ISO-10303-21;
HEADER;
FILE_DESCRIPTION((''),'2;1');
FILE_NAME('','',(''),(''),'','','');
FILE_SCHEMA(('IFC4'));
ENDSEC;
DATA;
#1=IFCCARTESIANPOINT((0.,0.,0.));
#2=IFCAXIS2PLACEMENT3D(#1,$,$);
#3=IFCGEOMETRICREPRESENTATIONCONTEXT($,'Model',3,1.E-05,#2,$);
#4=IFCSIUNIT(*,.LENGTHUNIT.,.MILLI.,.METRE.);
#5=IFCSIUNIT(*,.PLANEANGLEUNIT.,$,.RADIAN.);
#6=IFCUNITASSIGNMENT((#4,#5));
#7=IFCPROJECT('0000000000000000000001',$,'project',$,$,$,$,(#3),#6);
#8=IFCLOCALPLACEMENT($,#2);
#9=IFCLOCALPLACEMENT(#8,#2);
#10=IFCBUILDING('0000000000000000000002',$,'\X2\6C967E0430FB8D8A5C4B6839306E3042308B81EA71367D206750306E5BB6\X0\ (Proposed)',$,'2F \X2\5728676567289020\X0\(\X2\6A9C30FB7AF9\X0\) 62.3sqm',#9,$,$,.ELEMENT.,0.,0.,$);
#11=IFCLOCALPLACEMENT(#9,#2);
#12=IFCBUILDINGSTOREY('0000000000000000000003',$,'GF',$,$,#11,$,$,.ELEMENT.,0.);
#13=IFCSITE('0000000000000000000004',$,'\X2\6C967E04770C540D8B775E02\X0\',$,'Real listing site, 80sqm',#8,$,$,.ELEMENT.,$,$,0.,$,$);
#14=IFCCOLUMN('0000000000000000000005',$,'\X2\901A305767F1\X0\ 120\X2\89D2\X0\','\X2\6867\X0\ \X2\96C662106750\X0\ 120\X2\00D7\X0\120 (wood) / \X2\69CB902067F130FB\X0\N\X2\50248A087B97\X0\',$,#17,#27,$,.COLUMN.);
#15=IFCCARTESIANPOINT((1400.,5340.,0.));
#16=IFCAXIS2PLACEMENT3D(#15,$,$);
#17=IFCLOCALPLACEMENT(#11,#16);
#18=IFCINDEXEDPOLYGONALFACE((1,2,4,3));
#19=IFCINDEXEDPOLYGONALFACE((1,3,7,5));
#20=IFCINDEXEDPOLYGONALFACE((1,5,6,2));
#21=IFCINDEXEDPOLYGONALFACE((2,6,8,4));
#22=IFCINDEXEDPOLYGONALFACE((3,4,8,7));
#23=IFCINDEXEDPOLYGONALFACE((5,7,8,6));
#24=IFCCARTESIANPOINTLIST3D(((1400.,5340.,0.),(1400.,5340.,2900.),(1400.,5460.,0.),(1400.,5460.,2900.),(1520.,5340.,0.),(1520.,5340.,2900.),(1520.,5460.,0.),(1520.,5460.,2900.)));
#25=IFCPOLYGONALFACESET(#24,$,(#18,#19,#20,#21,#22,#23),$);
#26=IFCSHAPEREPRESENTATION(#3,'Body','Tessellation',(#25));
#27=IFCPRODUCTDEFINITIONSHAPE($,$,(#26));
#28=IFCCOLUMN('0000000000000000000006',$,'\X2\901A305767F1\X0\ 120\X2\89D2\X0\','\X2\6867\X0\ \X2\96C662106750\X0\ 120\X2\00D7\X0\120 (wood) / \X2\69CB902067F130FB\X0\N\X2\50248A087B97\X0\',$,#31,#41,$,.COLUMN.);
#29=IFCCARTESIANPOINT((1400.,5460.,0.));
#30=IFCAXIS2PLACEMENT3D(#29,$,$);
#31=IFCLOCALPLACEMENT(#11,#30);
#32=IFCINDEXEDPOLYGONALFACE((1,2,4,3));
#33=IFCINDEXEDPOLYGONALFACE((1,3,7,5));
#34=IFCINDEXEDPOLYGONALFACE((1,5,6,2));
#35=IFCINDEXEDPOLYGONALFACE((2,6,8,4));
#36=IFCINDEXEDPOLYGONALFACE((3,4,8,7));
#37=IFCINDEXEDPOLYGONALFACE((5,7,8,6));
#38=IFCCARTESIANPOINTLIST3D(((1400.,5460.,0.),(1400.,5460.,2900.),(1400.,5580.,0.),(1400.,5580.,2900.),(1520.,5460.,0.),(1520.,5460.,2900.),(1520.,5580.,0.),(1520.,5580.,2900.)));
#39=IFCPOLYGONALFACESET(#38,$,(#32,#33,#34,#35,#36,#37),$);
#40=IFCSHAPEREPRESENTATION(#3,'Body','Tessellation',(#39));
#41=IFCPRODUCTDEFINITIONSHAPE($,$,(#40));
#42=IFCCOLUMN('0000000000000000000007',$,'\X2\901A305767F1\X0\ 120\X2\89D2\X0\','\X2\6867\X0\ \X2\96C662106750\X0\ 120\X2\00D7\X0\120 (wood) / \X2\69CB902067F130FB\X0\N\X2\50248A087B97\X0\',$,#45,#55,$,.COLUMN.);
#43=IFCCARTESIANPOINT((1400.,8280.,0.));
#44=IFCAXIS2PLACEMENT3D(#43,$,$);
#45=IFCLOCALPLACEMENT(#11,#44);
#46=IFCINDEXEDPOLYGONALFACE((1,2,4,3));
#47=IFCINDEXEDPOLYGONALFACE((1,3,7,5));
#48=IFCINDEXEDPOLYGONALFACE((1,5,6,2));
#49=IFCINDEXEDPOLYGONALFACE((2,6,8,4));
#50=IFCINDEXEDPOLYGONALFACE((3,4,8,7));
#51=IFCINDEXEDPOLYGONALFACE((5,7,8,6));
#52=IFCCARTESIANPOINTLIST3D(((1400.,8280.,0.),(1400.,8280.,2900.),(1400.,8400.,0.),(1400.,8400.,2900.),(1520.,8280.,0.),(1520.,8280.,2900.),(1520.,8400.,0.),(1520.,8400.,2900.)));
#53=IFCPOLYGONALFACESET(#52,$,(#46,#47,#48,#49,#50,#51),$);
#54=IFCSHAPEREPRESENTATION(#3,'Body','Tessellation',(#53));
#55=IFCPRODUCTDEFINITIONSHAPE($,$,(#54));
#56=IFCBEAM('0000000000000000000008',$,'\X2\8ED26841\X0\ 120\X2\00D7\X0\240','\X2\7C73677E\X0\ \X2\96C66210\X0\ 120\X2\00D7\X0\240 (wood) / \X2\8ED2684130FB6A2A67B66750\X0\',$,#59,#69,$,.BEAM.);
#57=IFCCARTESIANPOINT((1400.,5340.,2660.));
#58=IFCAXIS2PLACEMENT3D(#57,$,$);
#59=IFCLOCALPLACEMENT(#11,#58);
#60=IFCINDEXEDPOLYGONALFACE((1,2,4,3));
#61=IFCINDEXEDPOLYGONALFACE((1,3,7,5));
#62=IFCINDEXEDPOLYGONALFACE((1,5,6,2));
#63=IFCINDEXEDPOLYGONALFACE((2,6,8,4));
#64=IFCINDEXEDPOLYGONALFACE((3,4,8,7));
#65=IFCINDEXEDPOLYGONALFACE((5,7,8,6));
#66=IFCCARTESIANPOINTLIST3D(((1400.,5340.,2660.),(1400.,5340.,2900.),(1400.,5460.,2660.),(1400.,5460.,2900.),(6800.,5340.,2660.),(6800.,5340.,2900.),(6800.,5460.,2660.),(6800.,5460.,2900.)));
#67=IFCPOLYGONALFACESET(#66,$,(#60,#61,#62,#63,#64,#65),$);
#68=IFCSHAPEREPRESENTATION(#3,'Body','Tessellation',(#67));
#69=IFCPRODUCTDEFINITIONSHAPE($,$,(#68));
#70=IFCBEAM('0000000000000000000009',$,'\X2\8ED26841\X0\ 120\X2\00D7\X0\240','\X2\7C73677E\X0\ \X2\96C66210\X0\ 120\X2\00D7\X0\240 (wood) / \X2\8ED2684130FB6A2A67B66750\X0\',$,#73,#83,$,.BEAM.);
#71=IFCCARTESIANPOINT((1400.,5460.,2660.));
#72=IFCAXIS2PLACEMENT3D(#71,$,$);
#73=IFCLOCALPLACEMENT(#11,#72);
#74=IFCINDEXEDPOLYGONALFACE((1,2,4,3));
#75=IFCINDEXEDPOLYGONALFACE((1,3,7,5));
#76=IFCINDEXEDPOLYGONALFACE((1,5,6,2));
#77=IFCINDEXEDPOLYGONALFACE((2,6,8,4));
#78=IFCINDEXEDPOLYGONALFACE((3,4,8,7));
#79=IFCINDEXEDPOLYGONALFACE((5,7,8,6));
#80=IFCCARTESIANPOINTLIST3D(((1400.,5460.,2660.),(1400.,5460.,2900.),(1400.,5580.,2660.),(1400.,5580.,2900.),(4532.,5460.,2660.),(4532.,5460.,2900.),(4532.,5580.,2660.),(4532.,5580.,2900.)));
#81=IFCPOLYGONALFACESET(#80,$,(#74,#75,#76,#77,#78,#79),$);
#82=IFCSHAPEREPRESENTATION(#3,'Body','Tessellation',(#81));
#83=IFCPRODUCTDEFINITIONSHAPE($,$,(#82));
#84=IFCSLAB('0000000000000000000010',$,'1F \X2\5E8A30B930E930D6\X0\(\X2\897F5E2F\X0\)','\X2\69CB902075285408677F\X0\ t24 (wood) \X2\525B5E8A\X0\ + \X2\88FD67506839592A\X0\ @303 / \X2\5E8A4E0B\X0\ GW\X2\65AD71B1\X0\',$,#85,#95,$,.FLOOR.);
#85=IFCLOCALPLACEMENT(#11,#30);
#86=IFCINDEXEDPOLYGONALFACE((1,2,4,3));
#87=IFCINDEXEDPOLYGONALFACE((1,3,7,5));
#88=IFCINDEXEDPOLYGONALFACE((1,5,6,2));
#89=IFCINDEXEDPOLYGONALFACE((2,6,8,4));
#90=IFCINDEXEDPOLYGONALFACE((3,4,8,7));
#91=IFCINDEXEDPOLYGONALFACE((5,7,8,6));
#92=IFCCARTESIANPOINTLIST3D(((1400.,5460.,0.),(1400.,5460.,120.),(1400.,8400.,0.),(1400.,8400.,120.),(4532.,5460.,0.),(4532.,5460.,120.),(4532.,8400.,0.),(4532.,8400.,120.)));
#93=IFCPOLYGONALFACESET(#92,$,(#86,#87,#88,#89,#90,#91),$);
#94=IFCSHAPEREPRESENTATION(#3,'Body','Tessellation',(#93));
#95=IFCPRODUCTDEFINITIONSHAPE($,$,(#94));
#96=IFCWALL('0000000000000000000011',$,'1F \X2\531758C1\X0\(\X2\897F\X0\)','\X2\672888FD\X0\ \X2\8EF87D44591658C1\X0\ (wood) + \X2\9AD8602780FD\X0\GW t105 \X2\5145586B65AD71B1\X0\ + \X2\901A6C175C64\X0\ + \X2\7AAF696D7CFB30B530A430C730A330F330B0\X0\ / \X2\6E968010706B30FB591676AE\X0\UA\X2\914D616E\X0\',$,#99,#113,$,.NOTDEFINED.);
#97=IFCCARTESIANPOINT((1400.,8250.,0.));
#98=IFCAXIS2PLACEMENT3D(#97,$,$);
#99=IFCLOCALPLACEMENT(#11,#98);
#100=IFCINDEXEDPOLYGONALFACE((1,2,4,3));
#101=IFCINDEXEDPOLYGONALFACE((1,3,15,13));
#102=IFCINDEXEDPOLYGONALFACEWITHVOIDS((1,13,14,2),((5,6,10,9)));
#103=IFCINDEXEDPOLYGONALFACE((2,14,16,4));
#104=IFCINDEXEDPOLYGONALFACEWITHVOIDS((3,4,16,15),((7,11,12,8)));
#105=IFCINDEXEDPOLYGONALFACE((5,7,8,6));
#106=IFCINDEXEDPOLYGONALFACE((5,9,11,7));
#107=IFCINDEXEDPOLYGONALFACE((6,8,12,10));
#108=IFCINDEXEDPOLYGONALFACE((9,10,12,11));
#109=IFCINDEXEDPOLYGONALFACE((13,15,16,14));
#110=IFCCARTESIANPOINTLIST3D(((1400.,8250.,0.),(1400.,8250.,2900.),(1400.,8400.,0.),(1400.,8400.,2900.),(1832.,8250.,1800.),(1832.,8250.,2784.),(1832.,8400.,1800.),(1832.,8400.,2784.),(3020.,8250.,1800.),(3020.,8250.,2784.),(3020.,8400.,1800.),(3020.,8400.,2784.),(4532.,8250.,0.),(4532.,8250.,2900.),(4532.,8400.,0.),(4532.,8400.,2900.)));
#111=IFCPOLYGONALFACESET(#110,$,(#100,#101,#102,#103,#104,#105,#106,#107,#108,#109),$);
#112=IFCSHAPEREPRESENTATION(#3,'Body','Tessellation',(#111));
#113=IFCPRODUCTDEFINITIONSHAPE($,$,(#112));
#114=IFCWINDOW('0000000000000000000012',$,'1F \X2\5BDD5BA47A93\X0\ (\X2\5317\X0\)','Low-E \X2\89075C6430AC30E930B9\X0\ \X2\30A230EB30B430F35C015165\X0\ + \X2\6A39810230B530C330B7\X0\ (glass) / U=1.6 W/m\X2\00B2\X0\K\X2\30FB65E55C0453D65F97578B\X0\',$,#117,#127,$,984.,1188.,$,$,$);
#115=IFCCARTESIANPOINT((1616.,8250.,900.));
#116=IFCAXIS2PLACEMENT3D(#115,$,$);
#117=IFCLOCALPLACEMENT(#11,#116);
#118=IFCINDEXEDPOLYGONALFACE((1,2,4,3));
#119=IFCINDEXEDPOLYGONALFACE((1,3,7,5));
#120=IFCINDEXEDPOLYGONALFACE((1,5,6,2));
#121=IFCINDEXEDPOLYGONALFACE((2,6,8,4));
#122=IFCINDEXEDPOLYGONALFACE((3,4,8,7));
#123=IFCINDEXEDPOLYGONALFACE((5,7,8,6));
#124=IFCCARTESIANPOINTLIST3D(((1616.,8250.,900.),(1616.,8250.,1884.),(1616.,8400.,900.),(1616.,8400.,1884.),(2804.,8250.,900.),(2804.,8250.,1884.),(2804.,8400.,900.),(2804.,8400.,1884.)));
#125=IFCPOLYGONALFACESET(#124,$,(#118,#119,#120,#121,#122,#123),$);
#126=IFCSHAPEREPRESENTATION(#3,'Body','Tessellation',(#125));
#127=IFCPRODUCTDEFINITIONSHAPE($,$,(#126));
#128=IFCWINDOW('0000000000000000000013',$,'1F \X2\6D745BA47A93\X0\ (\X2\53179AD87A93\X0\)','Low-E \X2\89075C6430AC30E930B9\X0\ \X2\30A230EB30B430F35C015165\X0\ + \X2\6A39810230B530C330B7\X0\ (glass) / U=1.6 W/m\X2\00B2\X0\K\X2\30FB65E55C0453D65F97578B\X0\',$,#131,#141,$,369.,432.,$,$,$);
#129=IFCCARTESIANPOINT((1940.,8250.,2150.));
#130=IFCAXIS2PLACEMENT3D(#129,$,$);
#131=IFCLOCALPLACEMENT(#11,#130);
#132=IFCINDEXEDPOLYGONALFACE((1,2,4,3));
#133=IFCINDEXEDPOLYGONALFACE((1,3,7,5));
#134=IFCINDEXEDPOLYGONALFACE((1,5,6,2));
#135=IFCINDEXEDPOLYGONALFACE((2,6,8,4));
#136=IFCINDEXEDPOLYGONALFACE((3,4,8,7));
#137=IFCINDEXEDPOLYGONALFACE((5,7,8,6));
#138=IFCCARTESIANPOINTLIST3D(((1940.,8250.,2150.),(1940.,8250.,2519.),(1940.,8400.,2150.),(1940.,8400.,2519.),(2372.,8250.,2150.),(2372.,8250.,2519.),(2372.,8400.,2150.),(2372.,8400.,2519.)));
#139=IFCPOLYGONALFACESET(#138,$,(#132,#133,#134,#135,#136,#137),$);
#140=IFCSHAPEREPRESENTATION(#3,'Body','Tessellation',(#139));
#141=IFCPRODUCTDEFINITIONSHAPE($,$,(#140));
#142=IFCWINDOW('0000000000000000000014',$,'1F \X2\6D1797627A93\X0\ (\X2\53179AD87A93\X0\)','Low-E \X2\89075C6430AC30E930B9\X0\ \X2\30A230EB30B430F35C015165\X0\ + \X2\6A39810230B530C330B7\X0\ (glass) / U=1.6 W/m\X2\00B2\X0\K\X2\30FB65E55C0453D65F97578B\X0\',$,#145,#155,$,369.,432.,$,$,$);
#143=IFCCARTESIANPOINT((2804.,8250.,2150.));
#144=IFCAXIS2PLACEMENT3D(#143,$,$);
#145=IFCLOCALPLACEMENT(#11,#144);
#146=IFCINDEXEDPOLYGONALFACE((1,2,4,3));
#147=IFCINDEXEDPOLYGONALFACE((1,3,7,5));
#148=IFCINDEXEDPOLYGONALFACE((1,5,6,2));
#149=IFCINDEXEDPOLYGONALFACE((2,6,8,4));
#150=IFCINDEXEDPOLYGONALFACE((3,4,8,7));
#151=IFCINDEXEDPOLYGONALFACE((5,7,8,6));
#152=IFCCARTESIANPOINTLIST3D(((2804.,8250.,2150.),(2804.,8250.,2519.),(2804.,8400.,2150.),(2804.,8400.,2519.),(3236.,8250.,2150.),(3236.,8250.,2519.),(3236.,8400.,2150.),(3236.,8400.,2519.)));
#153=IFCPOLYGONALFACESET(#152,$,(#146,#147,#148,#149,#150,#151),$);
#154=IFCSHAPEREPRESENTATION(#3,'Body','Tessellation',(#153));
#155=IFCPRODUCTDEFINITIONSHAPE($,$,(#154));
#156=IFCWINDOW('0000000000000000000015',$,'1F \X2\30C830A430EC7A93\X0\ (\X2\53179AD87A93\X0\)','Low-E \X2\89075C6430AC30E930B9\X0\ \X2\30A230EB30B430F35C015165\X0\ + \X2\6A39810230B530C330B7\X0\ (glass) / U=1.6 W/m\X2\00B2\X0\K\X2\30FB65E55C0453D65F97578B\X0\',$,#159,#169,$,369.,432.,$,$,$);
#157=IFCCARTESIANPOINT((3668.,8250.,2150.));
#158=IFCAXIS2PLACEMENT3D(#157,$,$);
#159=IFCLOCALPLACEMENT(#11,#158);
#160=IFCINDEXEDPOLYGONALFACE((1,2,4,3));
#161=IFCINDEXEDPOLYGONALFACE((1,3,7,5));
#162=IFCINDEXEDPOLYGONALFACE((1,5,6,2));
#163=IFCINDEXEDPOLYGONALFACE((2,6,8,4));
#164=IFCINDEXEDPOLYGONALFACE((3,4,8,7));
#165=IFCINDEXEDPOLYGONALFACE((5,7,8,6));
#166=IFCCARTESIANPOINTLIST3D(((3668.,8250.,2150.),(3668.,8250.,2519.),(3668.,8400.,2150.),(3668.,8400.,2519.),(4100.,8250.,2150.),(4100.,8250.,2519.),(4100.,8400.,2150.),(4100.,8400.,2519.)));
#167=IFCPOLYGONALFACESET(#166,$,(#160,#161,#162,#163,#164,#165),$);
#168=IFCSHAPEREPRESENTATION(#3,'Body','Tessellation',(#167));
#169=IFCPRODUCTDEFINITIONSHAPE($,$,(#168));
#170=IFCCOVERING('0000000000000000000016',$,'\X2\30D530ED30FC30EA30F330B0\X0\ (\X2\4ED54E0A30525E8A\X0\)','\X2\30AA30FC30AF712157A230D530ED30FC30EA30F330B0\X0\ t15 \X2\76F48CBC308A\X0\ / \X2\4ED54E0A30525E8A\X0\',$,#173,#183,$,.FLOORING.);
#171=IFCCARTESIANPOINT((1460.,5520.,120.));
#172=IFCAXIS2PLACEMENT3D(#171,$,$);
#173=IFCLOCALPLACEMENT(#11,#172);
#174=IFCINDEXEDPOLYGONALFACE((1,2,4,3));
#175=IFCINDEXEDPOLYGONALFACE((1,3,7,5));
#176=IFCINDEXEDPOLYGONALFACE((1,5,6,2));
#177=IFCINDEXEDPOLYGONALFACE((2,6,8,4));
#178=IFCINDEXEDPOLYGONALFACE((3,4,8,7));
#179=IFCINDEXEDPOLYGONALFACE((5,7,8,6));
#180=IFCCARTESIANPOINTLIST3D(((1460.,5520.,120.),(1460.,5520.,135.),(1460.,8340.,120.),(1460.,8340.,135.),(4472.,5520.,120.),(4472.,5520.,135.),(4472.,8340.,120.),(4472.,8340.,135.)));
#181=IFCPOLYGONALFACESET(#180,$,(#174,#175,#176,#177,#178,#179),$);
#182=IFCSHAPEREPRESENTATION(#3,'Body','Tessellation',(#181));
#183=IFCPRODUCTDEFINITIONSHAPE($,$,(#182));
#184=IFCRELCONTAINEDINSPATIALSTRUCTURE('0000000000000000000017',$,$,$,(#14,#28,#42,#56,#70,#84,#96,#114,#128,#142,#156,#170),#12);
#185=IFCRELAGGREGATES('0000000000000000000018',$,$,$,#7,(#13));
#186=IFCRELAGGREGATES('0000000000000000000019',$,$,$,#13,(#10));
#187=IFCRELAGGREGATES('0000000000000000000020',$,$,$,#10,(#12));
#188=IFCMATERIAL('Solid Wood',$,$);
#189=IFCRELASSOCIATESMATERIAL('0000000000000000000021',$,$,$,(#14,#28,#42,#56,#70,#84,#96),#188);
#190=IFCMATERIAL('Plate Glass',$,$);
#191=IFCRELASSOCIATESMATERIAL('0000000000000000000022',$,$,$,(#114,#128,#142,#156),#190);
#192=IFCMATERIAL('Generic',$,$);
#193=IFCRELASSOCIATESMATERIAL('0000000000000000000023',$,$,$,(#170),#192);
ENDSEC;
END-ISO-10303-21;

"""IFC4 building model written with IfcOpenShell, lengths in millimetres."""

from ifc_helpers import new_model, si_unit, frame, frame_2d, origin, place, context, project, spatial, rectangle, extrude, material, element, fill, save


model = new_model("IFC4")

# Units and contexts
model_context = context("Model", 3, precision=1e-05, world=origin())
ifc_project = project(units=[si_unit("LENGTHUNIT", "METRE", prefix="MILLI"), si_unit("PLANEANGLEUNIT", "RADIAN")], contexts=[model_context])

# Site, building, storey
site_placement = place(None, origin())
site = spatial("IfcSite", under=ifc_project, at=site_placement, Name="沖縄県名護市", ObjectType="Real listing site, 80sqm", CompositionType="ELEMENT", RefElevation=0.0)
building_placement = place(site_placement, origin())
building = spatial("IfcBuilding", under=site, at=building_placement, Name="沖縄・越屋根のある自然素材の家 (Proposed)", ObjectType="2F 在来木造(檜・竹) 62.3sqm", CompositionType="ELEMENT", ElevationOfRefHeight=0.0, ElevationOfTerrain=0.0)
storey_placement = place(building_placement, origin())
storey = spatial("IfcBuildingStorey", under=building, at=storey_placement, Name="GF", CompositionType="ELEMENT", Elevation=0.0)

# Columns
ifc_material_1 = material(Name="Solid Wood")
column_1_placement = place(storey_placement, frame((1400.0, 5340.0, 0.0)))
element("IfcColumn", 1, at=column_1_placement, inside=storey, material=ifc_material_1, Name="通し柱 120角", Description="桧 集成材 120×120 (wood) / 構造柱・N値計算", PredefinedType="COLUMN", context=model_context, shape_type="SweptSolid", body=[
    extrude(rectangle(XDim=120.0, YDim=120.0, at=frame_2d((60.0, 60.0))), frame((1400.0, 5340.0, 0.0)), (0.0, 0.0, 1.0), 2900.0),
])
column_2_placement = place(storey_placement, frame((1400.0, 5460.0, 0.0)))
element("IfcColumn", 2, at=column_2_placement, inside=storey, material=ifc_material_1, Name="通し柱 120角", Description="桧 集成材 120×120 (wood) / 構造柱・N値計算", PredefinedType="COLUMN", context=model_context, shape_type="SweptSolid", body=[
    extrude(rectangle(XDim=120.0, YDim=120.0, at=frame_2d((60.0, 60.0))), frame((1400.0, 5460.0, 0.0)), (0.0, 0.0, 1.0), 2900.0),
])
column_3_placement = place(storey_placement, frame((1400.0, 8280.0, 0.0)))
element("IfcColumn", 3, at=column_3_placement, inside=storey, material=ifc_material_1, Name="通し柱 120角", Description="桧 集成材 120×120 (wood) / 構造柱・N値計算", PredefinedType="COLUMN", context=model_context, shape_type="SweptSolid", body=[
    extrude(rectangle(XDim=120.0, YDim=120.0, at=frame_2d((60.0, 60.0))), frame((1400.0, 8280.0, 0.0)), (0.0, 0.0, 1.0), 2900.0),
])

# Beams
beam_1_placement = place(storey_placement, frame((1400.0, 5340.0, 2660.0)))
element("IfcBeam", 4, at=beam_1_placement, inside=storey, material=ifc_material_1, Name="軒桁 120×240", Description="米松 集成 120×240 (wood) / 軒桁・横架材", PredefinedType="BEAM", context=model_context, shape_type="SweptSolid", body=[
    extrude(rectangle(XDim=5400.0, YDim=120.0, at=frame_2d((2700.0, 60.0))), frame((1400.0, 5340.0, 2660.0)), (0.0, 0.0, 1.0), 240.0),
])
beam_2_placement = place(storey_placement, frame((1400.0, 5460.0, 2660.0)))
element("IfcBeam", 5, at=beam_2_placement, inside=storey, material=ifc_material_1, Name="軒桁 120×240", Description="米松 集成 120×240 (wood) / 軒桁・横架材", PredefinedType="BEAM", context=model_context, shape_type="SweptSolid", body=[
    extrude(rectangle(XDim=3132.0, YDim=120.0, at=frame_2d((1566.0, 60.0))), frame((1400.0, 5460.0, 2660.0)), (0.0, 0.0, 1.0), 240.0),
])

# Slab
slab_placement = place(storey_placement, frame((1400.0, 5460.0, 0.0)))
element("IfcSlab", 6, at=slab_placement, inside=storey, material=ifc_material_1, Name="1F 床スラブ(西帯)", Description="構造用合板 t24 (wood) 剛床 + 製材根太 @303 / 床下 GW断熱", PredefinedType="FLOOR", context=model_context, shape_type="SweptSolid", body=[
    extrude(rectangle(XDim=3132.0, YDim=2940.0, at=frame_2d((1566.0, 1470.0))), frame((1400.0, 5460.0, 0.0)), (0.0, 0.0, 1.0), 120.0),
])

# Wall, openings, windows
wall_1_placement = place(storey_placement, frame((1400.0, 8250.0, 0.0)))
wall_1 = element("IfcWall", 7, at=wall_1_placement, inside=storey, material=ifc_material_1, Name="1F 北壁(西)", Description="木製 軸組外壁 (wood) + 高性能GW t105 充填断熱 + 通気層 + 窯業系サイディング / 準耐火・外皮UA配慮", PredefinedType="NOTDEFINED", context=model_context, shape_type="SweptSolid", body=[
    extrude(rectangle(XDim=3132.0, YDim=150.0, at=frame_2d((1566.0, 75.0))), frame((1400.0, 8250.0, 0.0)), (0.0, 0.0, 1.0), 2900.0),
])
opening_1_placement = place(storey_placement, frame((1616.0, 8250.0, 900.0)))
opening_1 = element("IfcOpeningElement", 8, at=opening_1_placement, cuts=wall_1, PredefinedType="NOTDEFINED", context=model_context, shape_type="SweptSolid", body=[
    extrude(rectangle(XDim=1188.0, YDim=150.0, at=frame_2d((594.0, 75.0))), frame((1616.0, 8250.0, 900.0)), (0.0, 0.0, 1.0), 984.0),
])
opening_2_placement = place(storey_placement, frame((1940.0, 8250.0, 2150.0)))
opening_2 = element("IfcOpeningElement", 9, at=opening_2_placement, cuts=wall_1, PredefinedType="NOTDEFINED", context=model_context, shape_type="SweptSolid", body=[
    extrude(rectangle(XDim=432.0, YDim=150.0, at=frame_2d((216.0, 75.0))), frame((1940.0, 8250.0, 2150.0)), (0.0, 0.0, 1.0), 369.0),
])
opening_3_placement = place(storey_placement, frame((2804.0, 8250.0, 2150.0)))
opening_3 = element("IfcOpeningElement", 10, at=opening_3_placement, cuts=wall_1, PredefinedType="NOTDEFINED", context=model_context, shape_type="SweptSolid", body=[
    extrude(rectangle(XDim=432.0, YDim=150.0, at=frame_2d((216.0, 75.0))), frame((2804.0, 8250.0, 2150.0)), (0.0, 0.0, 1.0), 369.0),
])
opening_4_placement = place(storey_placement, frame((3668.0, 8250.0, 2150.0)))
opening_4 = element("IfcOpeningElement", 11, at=opening_4_placement, cuts=wall_1, PredefinedType="NOTDEFINED", context=model_context, shape_type="SweptSolid", body=[
    extrude(rectangle(XDim=432.0, YDim=150.0, at=frame_2d((216.0, 75.0))), frame((3668.0, 8250.0, 2150.0)), (0.0, 0.0, 1.0), 369.0),
])
ifc_material_2 = material(Name="Plate Glass")
window_1_placement = place(storey_placement, frame((1616.0, 8250.0, 900.0)))
window_1 = element("IfcWindow", 12, at=window_1_placement, inside=storey, material=ifc_material_2, Name="1F 寝室窓 (北)", Description="Low-E 複層ガラス アルゴン封入 + 樹脂サッシ (glass) / U=1.6 W/m²K・日射取得型", OverallHeight=984.0, OverallWidth=1188.0, context=model_context, shape_type="SweptSolid", body=[
    extrude(rectangle(XDim=1188.0, YDim=150.0, at=frame_2d((594.0, 75.0))), frame((1616.0, 8250.0, 900.0)), (0.0, 0.0, 1.0), 984.0),
])
fill(opening_1, window_1)
window_2_placement = place(storey_placement, frame((1940.0, 8250.0, 2150.0)))
window_2 = element("IfcWindow", 13, at=window_2_placement, inside=storey, material=ifc_material_2, Name="1F 浴室窓 (北高窓)", Description="Low-E 複層ガラス アルゴン封入 + 樹脂サッシ (glass) / U=1.6 W/m²K・日射取得型", OverallHeight=369.0, OverallWidth=432.0, context=model_context, shape_type="SweptSolid", body=[
    extrude(rectangle(XDim=432.0, YDim=150.0, at=frame_2d((216.0, 75.0))), frame((1940.0, 8250.0, 2150.0)), (0.0, 0.0, 1.0), 369.0),
])
fill(opening_2, window_2)
window_3_placement = place(storey_placement, frame((2804.0, 8250.0, 2150.0)))
window_3 = element("IfcWindow", 14, at=window_3_placement, inside=storey, material=ifc_material_2, Name="1F 洗面窓 (北高窓)", Description="Low-E 複層ガラス アルゴン封入 + 樹脂サッシ (glass) / U=1.6 W/m²K・日射取得型", OverallHeight=369.0, OverallWidth=432.0, context=model_context, shape_type="SweptSolid", body=[
    extrude(rectangle(XDim=432.0, YDim=150.0, at=frame_2d((216.0, 75.0))), frame((2804.0, 8250.0, 2150.0)), (0.0, 0.0, 1.0), 369.0),
])
fill(opening_3, window_3)
window_4_placement = place(storey_placement, frame((3668.0, 8250.0, 2150.0)))
window_4 = element("IfcWindow", 15, at=window_4_placement, inside=storey, material=ifc_material_2, Name="1F トイレ窓 (北高窓)", Description="Low-E 複層ガラス アルゴン封入 + 樹脂サッシ (glass) / U=1.6 W/m²K・日射取得型", OverallHeight=369.0, OverallWidth=432.0, context=model_context, shape_type="SweptSolid", body=[
    extrude(rectangle(XDim=432.0, YDim=150.0, at=frame_2d((216.0, 75.0))), frame((3668.0, 8250.0, 2150.0)), (0.0, 0.0, 1.0), 369.0),
])
fill(opening_4, window_4)

# Covering
ifc_material_3 = material(Name="Generic")
covering_placement = place(storey_placement, frame((1460.0, 5520.0, 120.0)))
element("IfcCovering", 16, at=covering_placement, inside=storey, material=ifc_material_3, Name="フローリング (仕上げ床)", Description="オーク無垢フローリング t15 直貼り / 仕上げ床", PredefinedType="FLOORING", context=model_context, shape_type="SweptSolid", body=[
    extrude(rectangle(XDim=3012.0, YDim=2820.0, at=frame_2d((1506.0, 1410.0))), frame((1460.0, 5520.0, 120.0)), (0.0, 0.0, 1.0), 15.0),
])

save(model, "model.ifc")
